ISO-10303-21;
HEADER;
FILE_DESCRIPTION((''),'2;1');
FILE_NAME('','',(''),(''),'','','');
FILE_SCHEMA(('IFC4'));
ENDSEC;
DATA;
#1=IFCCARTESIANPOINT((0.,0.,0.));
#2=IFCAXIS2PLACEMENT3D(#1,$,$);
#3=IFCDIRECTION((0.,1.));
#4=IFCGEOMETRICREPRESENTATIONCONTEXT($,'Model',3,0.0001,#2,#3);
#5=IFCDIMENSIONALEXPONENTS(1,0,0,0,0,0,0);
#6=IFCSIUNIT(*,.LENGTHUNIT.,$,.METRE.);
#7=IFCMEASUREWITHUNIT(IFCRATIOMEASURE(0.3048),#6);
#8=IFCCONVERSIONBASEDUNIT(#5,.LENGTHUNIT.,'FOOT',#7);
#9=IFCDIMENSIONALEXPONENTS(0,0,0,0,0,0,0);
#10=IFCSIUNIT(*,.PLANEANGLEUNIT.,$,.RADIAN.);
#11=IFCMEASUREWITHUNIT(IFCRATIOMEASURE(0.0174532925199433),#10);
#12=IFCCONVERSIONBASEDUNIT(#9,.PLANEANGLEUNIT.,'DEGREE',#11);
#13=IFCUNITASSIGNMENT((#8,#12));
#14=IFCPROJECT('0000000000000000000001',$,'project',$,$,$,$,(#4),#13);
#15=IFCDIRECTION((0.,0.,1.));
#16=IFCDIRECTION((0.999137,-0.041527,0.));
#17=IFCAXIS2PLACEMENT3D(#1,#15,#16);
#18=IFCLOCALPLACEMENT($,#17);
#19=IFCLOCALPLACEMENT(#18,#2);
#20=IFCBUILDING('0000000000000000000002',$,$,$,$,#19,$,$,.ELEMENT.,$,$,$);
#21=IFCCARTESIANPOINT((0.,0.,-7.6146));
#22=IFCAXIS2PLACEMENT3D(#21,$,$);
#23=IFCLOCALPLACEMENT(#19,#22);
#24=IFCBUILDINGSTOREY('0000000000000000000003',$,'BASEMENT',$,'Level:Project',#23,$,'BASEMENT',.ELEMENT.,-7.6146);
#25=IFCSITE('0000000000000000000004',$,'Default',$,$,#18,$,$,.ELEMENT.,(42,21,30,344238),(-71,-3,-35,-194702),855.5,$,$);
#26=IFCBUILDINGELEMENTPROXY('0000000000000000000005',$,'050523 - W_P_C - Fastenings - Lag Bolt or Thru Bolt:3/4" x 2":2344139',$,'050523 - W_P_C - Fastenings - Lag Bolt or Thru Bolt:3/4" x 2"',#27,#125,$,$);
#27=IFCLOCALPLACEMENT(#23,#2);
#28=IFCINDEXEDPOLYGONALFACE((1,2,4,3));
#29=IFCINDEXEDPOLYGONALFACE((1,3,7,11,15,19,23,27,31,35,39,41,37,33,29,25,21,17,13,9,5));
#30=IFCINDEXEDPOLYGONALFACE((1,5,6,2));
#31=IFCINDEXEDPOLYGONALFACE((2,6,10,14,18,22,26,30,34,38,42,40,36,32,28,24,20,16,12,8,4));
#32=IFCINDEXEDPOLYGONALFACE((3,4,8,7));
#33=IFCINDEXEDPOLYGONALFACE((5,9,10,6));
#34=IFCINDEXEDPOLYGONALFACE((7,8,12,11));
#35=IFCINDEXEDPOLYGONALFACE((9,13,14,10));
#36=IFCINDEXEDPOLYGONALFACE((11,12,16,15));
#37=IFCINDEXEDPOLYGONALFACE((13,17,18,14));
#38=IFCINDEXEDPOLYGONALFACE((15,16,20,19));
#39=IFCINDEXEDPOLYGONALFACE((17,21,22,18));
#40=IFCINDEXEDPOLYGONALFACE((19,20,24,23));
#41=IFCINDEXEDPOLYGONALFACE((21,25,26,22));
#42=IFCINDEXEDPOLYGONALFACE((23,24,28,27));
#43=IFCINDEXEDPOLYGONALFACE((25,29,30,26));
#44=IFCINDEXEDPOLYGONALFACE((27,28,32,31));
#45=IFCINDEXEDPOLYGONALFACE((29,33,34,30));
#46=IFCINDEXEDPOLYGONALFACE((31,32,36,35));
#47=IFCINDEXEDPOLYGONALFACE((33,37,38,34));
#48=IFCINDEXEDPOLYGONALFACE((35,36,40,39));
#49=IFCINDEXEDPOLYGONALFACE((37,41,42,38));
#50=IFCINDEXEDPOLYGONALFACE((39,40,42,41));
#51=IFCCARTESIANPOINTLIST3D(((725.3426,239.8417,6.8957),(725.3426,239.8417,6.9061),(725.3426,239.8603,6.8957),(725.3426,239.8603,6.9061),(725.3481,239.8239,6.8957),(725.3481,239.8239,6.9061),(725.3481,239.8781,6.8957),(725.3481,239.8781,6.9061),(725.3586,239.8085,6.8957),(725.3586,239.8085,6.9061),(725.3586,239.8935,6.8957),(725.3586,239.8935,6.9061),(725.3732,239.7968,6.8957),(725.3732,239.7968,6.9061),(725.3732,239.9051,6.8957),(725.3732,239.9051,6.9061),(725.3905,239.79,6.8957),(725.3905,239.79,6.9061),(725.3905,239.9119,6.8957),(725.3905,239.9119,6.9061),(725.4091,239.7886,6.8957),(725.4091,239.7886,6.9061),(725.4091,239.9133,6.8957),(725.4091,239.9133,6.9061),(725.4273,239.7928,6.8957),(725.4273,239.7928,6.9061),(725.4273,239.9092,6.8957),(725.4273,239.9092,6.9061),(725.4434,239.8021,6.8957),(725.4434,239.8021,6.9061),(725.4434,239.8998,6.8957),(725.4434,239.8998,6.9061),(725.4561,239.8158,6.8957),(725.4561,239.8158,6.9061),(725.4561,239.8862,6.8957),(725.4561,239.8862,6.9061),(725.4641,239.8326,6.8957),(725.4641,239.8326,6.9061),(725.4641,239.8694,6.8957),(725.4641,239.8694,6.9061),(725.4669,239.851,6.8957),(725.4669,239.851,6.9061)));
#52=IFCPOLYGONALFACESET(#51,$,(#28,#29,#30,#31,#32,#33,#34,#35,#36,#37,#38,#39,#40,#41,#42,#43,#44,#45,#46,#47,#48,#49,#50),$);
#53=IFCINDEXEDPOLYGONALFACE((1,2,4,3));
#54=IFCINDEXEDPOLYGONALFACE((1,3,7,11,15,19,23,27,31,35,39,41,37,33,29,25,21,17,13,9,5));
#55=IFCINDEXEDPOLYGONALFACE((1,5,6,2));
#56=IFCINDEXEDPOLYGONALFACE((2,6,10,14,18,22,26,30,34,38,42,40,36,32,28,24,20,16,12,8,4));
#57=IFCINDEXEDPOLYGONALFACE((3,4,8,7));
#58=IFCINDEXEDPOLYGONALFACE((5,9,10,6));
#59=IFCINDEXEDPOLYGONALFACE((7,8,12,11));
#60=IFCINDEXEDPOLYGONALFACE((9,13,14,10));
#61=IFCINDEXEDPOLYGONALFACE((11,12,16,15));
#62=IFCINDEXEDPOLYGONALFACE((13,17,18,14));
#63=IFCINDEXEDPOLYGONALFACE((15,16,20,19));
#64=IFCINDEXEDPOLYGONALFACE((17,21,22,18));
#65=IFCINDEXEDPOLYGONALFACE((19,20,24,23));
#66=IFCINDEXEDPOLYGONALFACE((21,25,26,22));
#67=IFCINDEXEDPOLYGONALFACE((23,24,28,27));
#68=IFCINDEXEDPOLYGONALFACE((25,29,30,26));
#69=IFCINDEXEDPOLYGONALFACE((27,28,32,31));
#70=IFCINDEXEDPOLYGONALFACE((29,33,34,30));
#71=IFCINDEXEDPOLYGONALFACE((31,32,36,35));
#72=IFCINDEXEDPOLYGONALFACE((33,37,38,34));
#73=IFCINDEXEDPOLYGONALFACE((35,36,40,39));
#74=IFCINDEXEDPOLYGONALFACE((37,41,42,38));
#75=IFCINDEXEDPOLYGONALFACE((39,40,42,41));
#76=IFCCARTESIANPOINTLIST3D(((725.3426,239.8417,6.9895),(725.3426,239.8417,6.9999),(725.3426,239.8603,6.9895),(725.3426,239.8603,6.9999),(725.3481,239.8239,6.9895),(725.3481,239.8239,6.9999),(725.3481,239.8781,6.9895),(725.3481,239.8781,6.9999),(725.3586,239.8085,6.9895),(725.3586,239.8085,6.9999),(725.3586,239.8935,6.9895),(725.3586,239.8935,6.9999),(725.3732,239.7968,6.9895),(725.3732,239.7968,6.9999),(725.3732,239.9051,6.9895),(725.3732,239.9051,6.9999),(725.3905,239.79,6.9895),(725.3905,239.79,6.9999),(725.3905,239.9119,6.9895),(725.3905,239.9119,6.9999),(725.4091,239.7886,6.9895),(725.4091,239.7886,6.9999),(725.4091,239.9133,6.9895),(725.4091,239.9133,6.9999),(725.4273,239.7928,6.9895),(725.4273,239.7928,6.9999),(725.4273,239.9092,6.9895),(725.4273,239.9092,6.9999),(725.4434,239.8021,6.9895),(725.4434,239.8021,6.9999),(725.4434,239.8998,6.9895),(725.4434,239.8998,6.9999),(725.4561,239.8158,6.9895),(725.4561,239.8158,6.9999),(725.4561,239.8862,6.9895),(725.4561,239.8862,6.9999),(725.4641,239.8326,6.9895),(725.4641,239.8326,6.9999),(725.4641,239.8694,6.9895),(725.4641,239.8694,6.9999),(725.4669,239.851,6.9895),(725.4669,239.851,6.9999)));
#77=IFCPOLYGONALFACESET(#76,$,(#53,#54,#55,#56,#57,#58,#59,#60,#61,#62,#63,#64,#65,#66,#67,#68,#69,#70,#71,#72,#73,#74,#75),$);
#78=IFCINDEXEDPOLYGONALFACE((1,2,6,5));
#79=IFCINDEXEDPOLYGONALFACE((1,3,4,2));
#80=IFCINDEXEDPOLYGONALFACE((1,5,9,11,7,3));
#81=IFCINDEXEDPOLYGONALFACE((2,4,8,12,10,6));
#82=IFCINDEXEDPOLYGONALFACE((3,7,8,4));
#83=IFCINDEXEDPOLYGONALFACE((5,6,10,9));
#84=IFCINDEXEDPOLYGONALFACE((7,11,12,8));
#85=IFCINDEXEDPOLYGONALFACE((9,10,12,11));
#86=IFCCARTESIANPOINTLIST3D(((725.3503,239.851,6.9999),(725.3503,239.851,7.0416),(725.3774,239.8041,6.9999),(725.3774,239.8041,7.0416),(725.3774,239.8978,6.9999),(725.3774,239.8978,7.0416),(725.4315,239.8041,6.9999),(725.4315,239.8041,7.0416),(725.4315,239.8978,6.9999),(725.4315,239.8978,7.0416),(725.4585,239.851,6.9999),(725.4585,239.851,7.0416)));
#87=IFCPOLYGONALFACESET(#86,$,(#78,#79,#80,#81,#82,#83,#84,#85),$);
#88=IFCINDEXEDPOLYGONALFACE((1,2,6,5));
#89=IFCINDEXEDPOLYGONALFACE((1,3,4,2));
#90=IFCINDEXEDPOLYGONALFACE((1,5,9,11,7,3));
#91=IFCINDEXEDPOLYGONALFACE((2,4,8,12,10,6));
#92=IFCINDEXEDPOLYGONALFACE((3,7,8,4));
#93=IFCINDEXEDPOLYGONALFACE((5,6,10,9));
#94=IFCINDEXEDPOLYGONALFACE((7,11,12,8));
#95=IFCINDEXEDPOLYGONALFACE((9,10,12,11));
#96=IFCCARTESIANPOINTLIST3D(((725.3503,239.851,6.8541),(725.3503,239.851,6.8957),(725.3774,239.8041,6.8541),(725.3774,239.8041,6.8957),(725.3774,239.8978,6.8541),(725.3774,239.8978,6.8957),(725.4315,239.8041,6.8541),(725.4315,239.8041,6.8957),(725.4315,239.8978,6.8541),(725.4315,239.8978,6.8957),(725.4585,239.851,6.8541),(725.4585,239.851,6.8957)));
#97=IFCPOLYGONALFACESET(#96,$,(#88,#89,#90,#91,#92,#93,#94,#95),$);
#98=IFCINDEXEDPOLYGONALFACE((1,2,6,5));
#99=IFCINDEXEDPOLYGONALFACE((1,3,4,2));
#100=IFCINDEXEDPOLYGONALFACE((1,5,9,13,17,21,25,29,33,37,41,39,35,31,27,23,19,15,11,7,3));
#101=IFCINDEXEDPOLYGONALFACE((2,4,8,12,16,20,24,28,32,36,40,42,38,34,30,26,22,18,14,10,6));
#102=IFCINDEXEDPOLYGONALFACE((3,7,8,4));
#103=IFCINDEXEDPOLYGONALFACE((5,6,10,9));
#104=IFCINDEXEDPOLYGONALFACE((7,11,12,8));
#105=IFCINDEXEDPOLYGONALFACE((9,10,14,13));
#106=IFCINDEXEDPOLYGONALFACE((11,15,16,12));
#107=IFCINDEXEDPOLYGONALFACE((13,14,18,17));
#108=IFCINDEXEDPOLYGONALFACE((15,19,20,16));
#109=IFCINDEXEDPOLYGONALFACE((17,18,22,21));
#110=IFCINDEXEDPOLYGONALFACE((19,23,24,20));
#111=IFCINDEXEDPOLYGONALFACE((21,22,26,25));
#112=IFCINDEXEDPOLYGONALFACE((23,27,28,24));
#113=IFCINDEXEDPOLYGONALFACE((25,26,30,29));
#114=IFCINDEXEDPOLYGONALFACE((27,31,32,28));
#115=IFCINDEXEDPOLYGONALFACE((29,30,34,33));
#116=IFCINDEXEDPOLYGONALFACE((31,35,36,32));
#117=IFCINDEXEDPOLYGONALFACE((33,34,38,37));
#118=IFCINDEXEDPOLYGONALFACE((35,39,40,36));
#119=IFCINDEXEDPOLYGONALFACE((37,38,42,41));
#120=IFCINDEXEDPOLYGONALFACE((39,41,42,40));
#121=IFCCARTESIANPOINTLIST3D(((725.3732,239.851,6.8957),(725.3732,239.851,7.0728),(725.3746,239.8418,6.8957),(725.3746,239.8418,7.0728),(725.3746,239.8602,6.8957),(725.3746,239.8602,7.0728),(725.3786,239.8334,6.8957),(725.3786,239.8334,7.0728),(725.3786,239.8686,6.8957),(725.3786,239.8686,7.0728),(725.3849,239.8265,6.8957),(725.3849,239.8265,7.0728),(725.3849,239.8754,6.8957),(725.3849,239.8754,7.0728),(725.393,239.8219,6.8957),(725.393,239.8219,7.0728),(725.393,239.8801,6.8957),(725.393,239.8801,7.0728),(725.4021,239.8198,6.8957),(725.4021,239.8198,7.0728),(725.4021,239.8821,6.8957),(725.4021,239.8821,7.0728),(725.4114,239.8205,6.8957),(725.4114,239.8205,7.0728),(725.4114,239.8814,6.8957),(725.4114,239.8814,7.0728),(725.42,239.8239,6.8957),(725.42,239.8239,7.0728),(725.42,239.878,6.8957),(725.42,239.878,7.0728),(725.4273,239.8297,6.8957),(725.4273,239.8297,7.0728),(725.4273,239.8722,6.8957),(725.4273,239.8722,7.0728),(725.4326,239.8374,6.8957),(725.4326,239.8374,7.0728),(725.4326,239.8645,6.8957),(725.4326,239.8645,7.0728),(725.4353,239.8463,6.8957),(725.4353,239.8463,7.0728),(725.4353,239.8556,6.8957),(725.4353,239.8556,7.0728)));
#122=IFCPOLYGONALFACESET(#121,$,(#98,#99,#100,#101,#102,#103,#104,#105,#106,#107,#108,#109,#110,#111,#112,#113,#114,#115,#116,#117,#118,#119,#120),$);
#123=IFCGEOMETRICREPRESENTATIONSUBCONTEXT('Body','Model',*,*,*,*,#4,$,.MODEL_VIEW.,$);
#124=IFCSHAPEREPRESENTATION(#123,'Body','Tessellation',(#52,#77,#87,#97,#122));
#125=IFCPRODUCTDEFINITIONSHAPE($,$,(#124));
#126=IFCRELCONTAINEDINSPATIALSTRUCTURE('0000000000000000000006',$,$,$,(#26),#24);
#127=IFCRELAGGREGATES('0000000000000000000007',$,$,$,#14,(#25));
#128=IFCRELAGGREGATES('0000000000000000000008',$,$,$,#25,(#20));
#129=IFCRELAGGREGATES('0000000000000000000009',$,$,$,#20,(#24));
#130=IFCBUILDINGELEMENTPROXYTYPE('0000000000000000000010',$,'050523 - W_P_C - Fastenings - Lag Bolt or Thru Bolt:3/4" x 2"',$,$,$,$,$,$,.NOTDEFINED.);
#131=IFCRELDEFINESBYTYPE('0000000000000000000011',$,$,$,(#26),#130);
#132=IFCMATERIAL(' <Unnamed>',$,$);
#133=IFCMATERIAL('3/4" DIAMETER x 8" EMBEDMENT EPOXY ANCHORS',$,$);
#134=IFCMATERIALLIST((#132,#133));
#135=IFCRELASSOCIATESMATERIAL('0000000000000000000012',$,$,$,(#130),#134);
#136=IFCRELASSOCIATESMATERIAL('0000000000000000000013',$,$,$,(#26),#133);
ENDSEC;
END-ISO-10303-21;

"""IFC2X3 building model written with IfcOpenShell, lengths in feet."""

from ifc_helpers import new_model, entity, si_unit, converted_unit, direction, frame, frame_2d, origin, place, context, subcontext, project, spatial, polyline, circle, outline, extrude, source, transform, mapped, material, material_list, type_object, type_shapes, element, save


model = new_model("IFC2X3")

# Units and contexts
model_context = context("Model", 3, precision=0.0001, world=origin(), true_north=direction((0.0, 1.0)))
body_context = subcontext(model_context, "Body", "Model", "MODEL_VIEW")
ifc_project = project(units=[converted_unit("LENGTHUNIT", "FOOT", entity("IfcRatioMeasure", 0.3048), si_unit("LENGTHUNIT", "METRE"), dimensions=[1, 0, 0, 0, 0, 0, 0]), converted_unit("PLANEANGLEUNIT", "DEGREE", entity("IfcRatioMeasure", 0.0174532925199433), si_unit("PLANEANGLEUNIT", "RADIAN"), dimensions=[0, 0, 0, 0, 0, 0, 0])], contexts=[model_context])

# Site, building, storey
site_placement = place(None, frame((0.0, 0.0, 0.0), z_axis=(0.0, 0.0, 1.0), x_axis=(0.999137, -0.041527, 0.0)))
site = spatial("IfcSite", under=ifc_project, at=site_placement, Name="Default", CompositionType="ELEMENT", RefLatitude=(42, 21, 30, 344238), RefLongitude=(-71, -3, -35, -194702), RefElevation=855.5)
building_placement = place(site_placement, origin())
building = spatial("IfcBuilding", under=site, at=building_placement, CompositionType="ELEMENT")
storey_placement = place(building_placement, frame((0.0, 0.0, -7.6146)))
storey = spatial("IfcBuildingStorey", under=building, at=storey_placement, Name="BASEMENT", ObjectType="Level:Project", LongName="BASEMENT", CompositionType="ELEMENT", Elevation=-7.6146)

# Building element proxy
ifc_material_1 = material(Name="3/4\" DIAMETER x 8\" EMBEDMENT EPOXY ANCHORS")
ifc_material_2 = material(Name=" <Unnamed>")
ifc_material_list_1 = material_list([ifc_material_2, ifc_material_1])
building_element_proxy_type_1 = type_object("IfcBuildingElementProxyType", Name="050523 - W_P_C - Fastenings - Lag Bolt or Thru Bolt:3/4\" x 2\"", PredefinedType="NOTDEFINED", material=ifc_material_list_1)
shared_shape_1 = source(origin(), body_context, "Body", "SweptSolid", [
    extrude(circle(Radius=0.0625, at=frame_2d((0.0, 0.0), x_axis=(1.0, 0.0))), frame((0.0, 0.0, 0.0), z_axis=(0.0, 0.0, 1.0), x_axis=(0.0, -1.0, 0.0)), (0.0, 0.0, 1.0), 0.0104),
    extrude(circle(Radius=0.0625, at=frame_2d((0.0, 0.0), x_axis=(1.0, 0.0))), frame((0.0, 0.0, -0.0938), z_axis=(0.0, 0.0, 1.0), x_axis=(0.0, -1.0, 0.0)), (0.0, 0.0, 1.0), 0.0104),
    extrude(outline(polyline([(-0.0271, -0.0469), (0.0271, -0.0469), (0.0541, 0.0), (0.0271, 0.0469), (-0.0271, 0.0469), (-0.0541, 0.0), (-0.0271, -0.0469)])), frame((0.0, 0.0, -0.1354), z_axis=(0.0, 0.0, 1.0), x_axis=(0.866025, -0.5, 0.0)), (0.0, 0.0, 1.0), 0.0417),
    extrude(outline(polyline([(-0.0271, -0.0469), (0.0271, -0.0469), (0.0541, 0.0), (0.0271, 0.0469), (-0.0271, 0.0469), (-0.0541, 0.0), (-0.0271, -0.0469)])), frame((0.0, 0.0, 0.0104), z_axis=(0.0, 0.0, 1.0), x_axis=(0.0, -1.0, 0.0)), (0.0, 0.0, 1.0), 0.0417),
    extrude(circle(Radius=0.0312, at=frame_2d((0.0, 0.0), x_axis=(1.0, 0.0))), frame((0.0, 0.0, -0.1667), z_axis=(0.0, 0.0, 1.0), x_axis=(0.0, 1.0, 0.0)), (0.0, 0.0, 1.0), 0.1771),
])
type_shapes(building_element_proxy_type_1, [shared_shape_1])
for number, where, z_axis, x_axis, name in (
    (1, (725.4044, 239.851, 6.9061), (0.0, 0.0, -1.0), (0.0, -1.0, 0.0), "050523 - W_P_C - Fastenings - Lag Bolt or Thru Bolt:3/4\" x 2\":2344139"),
):
    element("IfcBuildingElementProxy", number, at=place(storey_placement, frame(where, z_axis=z_axis, x_axis=x_axis)), inside=storey, type_object=building_element_proxy_type_1, material=ifc_material_1, Name=name, ObjectType="050523 - W_P_C - Fastenings - Lag Bolt or Thru Bolt:3/4\" x 2\"", context=body_context, shape_type="MappedRepresentation", body=[
        mapped(shared_shape_1, transform((0.0, 0.0, 0.0), scale=1.0)),
    ])

save(model, "model.ifc")
